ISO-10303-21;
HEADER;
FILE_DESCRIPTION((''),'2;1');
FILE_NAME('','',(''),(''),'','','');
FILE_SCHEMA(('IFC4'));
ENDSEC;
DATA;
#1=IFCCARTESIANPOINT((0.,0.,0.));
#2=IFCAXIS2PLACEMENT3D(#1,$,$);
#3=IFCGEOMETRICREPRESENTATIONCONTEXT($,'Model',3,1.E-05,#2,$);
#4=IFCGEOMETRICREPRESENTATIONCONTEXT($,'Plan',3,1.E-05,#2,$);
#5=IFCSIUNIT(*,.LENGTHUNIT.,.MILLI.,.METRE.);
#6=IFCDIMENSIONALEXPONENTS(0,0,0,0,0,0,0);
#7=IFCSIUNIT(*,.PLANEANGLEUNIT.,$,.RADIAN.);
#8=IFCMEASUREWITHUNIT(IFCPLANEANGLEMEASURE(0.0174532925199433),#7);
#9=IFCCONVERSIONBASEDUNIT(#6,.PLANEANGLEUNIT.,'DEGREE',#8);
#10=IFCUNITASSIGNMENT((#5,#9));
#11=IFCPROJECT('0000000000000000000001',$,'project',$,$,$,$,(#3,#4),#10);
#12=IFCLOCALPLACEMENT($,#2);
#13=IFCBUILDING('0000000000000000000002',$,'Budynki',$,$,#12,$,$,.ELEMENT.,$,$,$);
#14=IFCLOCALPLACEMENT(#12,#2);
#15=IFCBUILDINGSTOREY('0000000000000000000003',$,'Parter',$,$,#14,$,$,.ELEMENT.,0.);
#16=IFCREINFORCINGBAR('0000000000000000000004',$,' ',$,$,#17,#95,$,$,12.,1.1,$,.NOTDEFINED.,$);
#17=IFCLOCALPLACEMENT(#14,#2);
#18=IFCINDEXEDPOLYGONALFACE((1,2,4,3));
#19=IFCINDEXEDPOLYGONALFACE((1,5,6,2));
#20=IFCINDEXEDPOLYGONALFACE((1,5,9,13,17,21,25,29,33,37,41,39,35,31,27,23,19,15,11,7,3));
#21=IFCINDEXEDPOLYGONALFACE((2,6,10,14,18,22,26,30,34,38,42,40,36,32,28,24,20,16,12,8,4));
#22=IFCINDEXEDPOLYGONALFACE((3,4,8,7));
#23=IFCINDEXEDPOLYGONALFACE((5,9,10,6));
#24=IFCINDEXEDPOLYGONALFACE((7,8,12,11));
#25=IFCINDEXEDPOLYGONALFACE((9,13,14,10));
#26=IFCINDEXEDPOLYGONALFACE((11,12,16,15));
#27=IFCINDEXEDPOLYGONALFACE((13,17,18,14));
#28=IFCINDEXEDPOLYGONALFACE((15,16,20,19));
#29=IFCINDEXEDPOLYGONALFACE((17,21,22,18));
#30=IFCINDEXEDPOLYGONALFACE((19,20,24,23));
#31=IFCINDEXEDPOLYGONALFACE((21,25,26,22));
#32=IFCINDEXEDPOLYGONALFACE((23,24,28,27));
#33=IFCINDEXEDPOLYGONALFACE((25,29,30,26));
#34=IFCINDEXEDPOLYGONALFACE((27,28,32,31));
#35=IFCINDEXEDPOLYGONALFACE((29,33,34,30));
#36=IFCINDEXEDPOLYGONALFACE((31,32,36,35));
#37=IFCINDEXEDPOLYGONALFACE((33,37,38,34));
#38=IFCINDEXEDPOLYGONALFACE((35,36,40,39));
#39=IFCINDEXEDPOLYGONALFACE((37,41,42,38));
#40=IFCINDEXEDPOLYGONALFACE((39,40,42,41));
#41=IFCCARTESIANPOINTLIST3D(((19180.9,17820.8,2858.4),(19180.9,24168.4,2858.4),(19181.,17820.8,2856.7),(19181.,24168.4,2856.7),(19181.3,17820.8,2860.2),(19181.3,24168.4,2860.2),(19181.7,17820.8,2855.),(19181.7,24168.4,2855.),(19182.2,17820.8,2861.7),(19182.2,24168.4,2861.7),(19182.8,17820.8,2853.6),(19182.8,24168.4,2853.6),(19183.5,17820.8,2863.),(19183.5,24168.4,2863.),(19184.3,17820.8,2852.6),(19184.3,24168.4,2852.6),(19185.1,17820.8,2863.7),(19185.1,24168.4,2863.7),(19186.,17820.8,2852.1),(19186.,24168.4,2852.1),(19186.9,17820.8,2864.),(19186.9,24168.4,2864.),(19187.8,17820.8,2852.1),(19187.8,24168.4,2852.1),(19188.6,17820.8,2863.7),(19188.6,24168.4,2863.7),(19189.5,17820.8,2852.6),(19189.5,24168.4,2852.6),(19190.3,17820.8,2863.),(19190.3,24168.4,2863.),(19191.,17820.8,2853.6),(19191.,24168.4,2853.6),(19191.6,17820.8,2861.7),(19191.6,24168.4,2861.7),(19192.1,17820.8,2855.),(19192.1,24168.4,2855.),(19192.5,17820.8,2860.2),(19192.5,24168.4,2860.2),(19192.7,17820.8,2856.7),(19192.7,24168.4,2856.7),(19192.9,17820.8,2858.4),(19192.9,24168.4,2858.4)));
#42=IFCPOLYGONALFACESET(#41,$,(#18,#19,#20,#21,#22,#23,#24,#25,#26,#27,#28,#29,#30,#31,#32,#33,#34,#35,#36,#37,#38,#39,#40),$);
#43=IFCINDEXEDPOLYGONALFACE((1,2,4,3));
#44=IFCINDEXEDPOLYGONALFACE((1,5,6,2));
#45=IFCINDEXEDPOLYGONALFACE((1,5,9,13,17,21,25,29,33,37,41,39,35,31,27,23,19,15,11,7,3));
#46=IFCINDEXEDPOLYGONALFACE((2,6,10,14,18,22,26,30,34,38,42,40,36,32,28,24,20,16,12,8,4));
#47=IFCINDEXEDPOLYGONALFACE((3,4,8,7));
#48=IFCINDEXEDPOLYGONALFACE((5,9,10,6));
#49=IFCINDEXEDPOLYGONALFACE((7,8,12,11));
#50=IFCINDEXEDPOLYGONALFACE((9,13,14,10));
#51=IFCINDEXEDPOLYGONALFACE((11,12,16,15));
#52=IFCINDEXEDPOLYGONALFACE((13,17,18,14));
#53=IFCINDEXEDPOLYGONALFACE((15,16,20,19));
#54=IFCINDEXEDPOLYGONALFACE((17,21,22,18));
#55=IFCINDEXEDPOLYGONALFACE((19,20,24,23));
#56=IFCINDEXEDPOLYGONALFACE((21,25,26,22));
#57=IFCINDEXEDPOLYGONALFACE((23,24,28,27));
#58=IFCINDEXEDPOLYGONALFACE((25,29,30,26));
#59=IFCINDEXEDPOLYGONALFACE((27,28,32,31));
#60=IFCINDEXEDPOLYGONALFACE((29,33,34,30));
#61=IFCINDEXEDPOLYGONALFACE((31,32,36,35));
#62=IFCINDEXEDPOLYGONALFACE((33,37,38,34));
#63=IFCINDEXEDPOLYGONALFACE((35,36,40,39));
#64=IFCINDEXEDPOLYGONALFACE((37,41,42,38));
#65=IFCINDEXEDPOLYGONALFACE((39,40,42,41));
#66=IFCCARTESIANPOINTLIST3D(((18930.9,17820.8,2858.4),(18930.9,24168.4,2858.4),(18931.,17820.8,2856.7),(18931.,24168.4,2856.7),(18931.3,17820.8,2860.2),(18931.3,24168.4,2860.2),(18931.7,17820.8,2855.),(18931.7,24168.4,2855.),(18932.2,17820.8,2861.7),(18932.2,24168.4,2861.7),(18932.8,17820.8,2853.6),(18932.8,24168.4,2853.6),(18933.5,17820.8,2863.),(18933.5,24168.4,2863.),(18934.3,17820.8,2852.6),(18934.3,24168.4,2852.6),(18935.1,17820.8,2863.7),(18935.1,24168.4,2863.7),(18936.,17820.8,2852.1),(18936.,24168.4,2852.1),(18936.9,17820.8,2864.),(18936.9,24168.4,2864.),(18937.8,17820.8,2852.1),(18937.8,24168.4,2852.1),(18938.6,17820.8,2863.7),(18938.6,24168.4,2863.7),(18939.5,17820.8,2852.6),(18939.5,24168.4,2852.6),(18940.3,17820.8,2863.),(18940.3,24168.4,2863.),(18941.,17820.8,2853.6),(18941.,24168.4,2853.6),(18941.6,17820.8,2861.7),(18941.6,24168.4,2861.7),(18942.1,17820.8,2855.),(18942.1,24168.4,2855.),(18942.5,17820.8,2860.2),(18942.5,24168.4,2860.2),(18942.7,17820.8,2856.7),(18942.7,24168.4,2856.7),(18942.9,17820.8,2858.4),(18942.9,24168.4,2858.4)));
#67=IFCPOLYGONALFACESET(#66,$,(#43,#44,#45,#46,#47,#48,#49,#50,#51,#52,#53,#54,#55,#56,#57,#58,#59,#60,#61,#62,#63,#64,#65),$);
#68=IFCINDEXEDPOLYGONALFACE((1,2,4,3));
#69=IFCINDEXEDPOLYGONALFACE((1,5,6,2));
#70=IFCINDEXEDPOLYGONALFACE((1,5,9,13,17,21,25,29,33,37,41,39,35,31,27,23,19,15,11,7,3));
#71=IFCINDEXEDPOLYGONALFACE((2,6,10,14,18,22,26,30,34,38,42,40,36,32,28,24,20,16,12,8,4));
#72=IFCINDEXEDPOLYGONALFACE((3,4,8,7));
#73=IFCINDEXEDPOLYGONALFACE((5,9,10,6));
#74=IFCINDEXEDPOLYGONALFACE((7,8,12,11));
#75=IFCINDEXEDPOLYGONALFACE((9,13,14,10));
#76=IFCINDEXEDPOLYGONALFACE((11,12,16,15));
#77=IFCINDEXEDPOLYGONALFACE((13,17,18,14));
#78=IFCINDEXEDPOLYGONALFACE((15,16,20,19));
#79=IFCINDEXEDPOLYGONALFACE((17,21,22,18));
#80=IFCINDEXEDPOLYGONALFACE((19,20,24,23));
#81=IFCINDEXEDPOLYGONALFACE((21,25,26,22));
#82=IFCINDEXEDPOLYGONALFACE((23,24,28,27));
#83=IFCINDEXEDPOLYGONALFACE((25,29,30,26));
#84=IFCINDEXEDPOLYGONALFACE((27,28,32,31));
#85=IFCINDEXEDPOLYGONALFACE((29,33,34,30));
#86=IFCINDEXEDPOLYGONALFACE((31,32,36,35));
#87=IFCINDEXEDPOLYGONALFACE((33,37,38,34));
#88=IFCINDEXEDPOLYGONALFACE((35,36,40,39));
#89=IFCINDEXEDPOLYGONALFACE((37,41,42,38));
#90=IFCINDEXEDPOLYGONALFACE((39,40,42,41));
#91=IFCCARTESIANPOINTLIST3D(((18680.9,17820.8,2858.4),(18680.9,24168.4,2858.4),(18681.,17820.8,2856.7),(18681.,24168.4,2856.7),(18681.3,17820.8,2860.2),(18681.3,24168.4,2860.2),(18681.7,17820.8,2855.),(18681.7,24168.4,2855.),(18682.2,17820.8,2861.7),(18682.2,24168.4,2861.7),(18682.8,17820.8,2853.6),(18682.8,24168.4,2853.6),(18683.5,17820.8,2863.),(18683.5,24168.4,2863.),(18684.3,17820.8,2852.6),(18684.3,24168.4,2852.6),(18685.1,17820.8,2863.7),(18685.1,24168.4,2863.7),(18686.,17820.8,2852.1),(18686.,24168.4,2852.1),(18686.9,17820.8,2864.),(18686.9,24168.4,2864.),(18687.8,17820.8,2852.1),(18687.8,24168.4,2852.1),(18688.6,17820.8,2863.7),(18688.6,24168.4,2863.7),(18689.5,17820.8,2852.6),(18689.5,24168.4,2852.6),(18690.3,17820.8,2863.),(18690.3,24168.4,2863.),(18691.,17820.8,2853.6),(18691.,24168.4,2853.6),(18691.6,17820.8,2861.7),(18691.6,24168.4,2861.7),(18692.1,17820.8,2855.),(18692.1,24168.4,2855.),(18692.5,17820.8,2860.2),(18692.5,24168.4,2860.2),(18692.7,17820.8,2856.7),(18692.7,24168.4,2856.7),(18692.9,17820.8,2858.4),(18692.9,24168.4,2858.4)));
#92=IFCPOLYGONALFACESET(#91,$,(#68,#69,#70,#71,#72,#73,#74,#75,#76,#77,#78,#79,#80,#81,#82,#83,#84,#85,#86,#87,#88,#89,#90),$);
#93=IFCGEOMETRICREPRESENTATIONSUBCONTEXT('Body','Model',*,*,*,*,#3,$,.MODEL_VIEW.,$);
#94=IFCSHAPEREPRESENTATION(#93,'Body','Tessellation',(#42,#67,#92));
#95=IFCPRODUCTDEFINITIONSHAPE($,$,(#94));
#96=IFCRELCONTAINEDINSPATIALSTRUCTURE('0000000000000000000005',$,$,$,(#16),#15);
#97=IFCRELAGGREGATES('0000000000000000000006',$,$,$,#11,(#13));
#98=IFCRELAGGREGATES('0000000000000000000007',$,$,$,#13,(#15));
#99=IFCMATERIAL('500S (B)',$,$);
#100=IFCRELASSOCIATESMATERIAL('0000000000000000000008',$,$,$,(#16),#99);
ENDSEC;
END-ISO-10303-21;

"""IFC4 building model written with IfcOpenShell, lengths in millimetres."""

from ifc_helpers import new_model, entity, si_unit, converted_unit, frame, origin, place, context, subcontext, project, spatial, material, element, save


model = new_model("IFC4")

# Units and contexts
model_context = context("Model", 3, precision=1e-05, world=origin())
plan_context = context("Plan", 3, precision=1e-05, world=origin())
body_context = subcontext(model_context, "Body", "Model", "MODEL_VIEW")
ifc_project = project(units=[si_unit("LENGTHUNIT", "METRE", prefix="MILLI"), converted_unit("PLANEANGLEUNIT", "DEGREE", entity("IfcPlaneAngleMeasure", 0.0174532925199433), si_unit("PLANEANGLEUNIT", "RADIAN"), dimensions=[0, 0, 0, 0, 0, 0, 0])], contexts=[model_context, plan_context])

# Building, storey
building_placement = place(None, origin())
building = spatial("IfcBuilding", under=ifc_project, at=building_placement, Name="Budynki", CompositionType="ELEMENT")
storey_placement = place(building_placement, origin())
storey = spatial("IfcBuildingStorey", under=building, at=storey_placement, Name="Parter", CompositionType="ELEMENT", Elevation=0.0)

# Reinforcing bar
ifc_material_1 = material(Name="500S (B)")
reinforcing_bar_1_placement = place(storey_placement, frame((19186.9, 17820.8, 2858.0)))
element("IfcReinforcingBar", 1, at=reinforcing_bar_1_placement, inside=storey, material=ifc_material_1, Name=" ", CrossSectionArea=1.1, NominalDiameter=12.0, PredefinedType="NOTDEFINED", context=body_context, shape_type="AdvancedSweptSolid", body=[
    entity("IfcSweptDiskSolid", entity("IfcPolyline", [entity("IfcCartesianPoint", [0.0, 0.0, 0.0]), entity("IfcCartesianPoint", [0.0, 6347.6, 0.0])]), 6.0, None, 0.0, 1.0),
    entity("IfcSweptDiskSolid", entity("IfcPolyline", [entity("IfcCartesianPoint", [-250.0, 0.0, 0.0]), entity("IfcCartesianPoint", [-250.0, 6347.6, 0.0])]), 6.0, None, 0.0, 1.0),
    entity("IfcSweptDiskSolid", entity("IfcPolyline", [entity("IfcCartesianPoint", [-500.0, 0.0, 0.0]), entity("IfcCartesianPoint", [-500.0, 6347.6, 0.0])]), 6.0, None, 0.0, 1.0),
])

save(model, "model.ifc")
